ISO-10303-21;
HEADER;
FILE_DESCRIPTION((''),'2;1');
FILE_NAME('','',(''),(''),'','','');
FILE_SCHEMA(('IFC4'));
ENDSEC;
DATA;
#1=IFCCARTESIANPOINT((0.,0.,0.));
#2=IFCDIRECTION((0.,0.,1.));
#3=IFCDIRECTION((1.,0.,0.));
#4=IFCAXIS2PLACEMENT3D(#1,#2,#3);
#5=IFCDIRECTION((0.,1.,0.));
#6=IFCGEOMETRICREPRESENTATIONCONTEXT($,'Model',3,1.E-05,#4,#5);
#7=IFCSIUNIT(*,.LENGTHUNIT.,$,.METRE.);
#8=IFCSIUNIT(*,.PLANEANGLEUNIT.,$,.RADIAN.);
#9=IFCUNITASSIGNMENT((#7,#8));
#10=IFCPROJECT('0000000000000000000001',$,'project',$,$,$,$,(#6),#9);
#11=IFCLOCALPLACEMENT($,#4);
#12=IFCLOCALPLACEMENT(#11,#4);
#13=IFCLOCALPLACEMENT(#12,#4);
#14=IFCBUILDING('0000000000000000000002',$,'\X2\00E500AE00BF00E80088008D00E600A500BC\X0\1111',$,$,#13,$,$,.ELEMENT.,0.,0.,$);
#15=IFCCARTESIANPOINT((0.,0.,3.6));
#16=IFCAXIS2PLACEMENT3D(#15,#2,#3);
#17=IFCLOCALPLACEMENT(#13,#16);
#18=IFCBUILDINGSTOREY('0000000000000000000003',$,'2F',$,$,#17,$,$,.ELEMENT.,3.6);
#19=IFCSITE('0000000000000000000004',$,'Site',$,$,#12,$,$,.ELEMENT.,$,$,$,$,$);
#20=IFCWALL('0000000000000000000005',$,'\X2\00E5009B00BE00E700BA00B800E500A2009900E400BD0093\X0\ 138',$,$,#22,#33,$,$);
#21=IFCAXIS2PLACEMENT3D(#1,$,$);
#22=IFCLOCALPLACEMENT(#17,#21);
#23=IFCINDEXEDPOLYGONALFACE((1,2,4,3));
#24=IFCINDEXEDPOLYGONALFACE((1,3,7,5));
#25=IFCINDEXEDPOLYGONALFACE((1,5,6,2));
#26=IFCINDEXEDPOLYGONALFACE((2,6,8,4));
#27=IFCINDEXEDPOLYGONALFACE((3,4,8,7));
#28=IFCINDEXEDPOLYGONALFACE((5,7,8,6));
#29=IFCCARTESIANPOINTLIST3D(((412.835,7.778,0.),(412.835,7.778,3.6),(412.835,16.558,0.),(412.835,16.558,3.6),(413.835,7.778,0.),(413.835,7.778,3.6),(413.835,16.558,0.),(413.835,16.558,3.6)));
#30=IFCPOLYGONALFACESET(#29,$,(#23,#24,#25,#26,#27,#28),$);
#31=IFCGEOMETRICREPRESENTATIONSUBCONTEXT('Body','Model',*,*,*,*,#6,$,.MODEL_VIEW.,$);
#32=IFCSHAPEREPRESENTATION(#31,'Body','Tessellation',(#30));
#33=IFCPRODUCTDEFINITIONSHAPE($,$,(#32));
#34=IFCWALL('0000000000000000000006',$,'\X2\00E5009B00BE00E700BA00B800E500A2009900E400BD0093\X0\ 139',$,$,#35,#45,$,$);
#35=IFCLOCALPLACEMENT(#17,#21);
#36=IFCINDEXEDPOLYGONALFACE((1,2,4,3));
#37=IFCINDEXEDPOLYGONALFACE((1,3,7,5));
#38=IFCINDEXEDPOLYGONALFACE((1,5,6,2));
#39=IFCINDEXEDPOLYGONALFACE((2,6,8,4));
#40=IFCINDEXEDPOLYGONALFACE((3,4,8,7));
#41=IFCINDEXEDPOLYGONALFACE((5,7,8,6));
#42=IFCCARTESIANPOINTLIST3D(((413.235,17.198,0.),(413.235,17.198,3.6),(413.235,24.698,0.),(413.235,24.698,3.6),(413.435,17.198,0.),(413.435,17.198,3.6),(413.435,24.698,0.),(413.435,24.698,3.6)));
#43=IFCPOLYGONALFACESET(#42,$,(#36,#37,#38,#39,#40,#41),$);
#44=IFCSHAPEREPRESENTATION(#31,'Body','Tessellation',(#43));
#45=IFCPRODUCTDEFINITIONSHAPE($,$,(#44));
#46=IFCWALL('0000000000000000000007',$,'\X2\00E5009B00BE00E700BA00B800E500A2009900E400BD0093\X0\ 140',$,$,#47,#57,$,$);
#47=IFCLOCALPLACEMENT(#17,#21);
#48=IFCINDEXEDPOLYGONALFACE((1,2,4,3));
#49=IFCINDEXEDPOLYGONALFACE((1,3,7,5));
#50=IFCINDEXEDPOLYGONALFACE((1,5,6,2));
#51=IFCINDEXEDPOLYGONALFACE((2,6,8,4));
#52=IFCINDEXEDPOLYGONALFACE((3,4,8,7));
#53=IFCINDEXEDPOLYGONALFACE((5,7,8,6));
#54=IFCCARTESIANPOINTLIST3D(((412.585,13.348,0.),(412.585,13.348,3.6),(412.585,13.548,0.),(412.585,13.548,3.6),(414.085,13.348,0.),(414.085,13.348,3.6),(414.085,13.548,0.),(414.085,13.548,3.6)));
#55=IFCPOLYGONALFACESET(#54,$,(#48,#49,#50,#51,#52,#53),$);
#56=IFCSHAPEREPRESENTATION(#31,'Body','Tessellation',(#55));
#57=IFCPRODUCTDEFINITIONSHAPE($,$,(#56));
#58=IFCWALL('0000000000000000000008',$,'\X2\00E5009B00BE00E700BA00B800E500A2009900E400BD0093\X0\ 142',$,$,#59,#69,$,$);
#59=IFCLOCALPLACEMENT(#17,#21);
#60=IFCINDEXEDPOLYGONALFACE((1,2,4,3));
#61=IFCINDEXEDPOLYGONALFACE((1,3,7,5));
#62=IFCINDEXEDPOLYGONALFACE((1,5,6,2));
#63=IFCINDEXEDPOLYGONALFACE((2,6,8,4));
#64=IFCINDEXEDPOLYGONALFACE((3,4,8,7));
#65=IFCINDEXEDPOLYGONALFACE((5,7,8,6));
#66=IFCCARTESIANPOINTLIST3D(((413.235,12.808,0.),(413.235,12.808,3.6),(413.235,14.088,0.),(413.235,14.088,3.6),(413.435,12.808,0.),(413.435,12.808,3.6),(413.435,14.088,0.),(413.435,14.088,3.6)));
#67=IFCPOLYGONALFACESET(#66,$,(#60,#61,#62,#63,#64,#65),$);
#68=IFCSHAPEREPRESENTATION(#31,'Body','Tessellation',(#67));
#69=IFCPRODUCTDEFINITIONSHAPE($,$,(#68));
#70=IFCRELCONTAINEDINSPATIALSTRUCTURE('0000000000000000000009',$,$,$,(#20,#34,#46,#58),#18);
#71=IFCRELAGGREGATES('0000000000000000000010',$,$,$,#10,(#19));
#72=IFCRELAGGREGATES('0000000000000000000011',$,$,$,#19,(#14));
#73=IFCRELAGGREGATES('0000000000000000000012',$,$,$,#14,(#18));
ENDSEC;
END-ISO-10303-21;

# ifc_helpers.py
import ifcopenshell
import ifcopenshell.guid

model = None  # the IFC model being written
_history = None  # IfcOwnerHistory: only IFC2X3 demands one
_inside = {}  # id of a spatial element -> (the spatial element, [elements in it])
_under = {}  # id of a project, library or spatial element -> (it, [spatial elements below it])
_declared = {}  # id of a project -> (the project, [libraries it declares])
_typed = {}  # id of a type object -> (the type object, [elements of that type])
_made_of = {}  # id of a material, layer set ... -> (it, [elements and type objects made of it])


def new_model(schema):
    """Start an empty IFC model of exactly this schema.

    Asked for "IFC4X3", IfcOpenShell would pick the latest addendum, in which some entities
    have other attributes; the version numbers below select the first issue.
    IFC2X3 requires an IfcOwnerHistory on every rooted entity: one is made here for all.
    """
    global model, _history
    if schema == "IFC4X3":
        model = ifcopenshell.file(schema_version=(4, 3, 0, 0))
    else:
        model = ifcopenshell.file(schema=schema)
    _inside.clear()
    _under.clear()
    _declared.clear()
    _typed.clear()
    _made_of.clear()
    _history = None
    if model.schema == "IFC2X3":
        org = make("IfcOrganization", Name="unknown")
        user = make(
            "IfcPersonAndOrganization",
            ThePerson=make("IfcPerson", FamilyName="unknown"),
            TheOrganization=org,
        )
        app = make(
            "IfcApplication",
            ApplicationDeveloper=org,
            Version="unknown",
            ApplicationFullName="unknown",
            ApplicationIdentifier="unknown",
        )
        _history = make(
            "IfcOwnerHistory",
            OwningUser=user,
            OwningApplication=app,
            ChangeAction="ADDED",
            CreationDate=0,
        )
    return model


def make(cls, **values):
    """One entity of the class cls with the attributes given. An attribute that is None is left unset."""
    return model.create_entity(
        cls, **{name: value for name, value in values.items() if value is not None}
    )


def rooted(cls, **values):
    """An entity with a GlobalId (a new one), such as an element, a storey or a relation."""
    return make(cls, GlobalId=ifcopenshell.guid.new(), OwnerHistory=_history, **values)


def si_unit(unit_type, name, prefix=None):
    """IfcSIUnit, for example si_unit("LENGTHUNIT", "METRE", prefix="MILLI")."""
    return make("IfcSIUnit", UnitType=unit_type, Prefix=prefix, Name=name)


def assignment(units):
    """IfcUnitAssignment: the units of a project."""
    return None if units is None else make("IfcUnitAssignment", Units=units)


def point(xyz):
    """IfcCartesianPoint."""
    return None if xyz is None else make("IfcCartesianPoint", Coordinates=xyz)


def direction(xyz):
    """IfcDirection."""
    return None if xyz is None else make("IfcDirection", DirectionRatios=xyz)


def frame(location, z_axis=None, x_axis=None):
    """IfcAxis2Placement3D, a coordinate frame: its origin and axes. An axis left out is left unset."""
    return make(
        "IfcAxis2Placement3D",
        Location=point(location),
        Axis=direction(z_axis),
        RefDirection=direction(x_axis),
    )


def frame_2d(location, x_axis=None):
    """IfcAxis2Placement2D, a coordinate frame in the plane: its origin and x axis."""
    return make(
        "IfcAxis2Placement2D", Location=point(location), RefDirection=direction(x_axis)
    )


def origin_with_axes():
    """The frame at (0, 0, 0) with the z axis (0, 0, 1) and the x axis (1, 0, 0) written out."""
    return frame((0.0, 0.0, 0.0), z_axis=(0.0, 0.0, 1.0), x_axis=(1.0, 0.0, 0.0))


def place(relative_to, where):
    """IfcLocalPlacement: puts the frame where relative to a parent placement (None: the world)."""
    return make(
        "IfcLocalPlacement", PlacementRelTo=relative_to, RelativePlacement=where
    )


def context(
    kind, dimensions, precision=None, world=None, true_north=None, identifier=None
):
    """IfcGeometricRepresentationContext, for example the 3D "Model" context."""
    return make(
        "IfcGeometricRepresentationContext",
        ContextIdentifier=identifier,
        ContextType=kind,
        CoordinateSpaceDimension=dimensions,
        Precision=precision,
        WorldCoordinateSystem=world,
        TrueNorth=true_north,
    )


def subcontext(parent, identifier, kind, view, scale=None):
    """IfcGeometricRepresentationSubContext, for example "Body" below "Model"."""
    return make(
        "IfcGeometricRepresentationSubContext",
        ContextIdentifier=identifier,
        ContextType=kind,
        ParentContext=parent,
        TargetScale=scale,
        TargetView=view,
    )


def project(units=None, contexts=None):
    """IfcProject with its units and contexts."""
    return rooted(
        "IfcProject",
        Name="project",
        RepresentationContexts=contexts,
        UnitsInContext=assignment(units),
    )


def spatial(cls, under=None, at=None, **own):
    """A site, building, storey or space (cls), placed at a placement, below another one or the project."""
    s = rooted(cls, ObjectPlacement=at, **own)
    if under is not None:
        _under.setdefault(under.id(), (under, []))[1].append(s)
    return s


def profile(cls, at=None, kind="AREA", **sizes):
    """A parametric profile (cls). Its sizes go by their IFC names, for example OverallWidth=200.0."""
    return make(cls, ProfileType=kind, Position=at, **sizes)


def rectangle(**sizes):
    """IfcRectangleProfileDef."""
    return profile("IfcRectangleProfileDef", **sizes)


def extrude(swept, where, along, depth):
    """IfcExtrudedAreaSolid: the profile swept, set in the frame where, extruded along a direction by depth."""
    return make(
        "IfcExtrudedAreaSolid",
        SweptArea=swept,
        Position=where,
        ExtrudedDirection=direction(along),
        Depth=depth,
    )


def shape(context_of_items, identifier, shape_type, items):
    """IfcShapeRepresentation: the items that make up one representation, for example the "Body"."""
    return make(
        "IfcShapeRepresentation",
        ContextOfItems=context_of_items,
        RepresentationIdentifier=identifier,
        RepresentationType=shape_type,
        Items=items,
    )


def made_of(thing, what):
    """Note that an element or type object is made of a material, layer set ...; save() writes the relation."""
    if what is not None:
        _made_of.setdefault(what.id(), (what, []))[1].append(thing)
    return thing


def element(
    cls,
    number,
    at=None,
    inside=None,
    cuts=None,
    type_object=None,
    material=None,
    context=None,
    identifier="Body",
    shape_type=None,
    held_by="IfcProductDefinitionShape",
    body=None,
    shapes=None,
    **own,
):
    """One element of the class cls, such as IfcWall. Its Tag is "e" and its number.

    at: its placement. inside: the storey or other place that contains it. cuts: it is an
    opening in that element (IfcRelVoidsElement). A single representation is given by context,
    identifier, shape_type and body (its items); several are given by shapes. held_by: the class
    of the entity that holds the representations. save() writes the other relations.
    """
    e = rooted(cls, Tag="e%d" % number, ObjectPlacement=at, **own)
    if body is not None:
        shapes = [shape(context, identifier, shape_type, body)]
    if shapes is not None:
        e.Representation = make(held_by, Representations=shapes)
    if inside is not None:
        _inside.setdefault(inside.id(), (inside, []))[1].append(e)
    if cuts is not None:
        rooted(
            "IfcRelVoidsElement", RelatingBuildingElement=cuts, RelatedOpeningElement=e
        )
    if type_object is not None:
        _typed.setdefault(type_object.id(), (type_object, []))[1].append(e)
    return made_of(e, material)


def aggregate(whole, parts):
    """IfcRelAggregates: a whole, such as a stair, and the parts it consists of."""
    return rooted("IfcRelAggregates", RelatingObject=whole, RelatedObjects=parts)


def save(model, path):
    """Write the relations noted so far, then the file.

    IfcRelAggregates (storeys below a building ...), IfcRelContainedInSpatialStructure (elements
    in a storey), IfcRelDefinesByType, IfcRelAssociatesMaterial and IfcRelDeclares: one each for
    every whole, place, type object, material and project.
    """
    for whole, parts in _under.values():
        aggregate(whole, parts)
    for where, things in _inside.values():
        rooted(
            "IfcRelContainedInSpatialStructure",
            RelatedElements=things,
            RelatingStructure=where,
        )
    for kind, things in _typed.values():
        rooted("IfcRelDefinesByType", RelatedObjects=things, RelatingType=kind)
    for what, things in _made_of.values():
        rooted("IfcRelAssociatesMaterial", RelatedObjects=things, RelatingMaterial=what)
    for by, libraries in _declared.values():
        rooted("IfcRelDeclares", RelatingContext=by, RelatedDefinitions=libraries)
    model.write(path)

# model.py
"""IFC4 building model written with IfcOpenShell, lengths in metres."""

from ifc_helpers import new_model, si_unit, direction, frame, frame_2d, origin_with_axes, place, context, subcontext, project, spatial, rectangle, extrude, element, save


model = new_model("IFC4")

# Units and contexts
model_context = context("Model", 3, precision=1e-05, world=origin_with_axes(), true_north=direction((0.0, 1.0, 0.0)))
body_context = subcontext(model_context, "Body", "Model", "MODEL_VIEW")
ifc_project = project(units=[si_unit("LENGTHUNIT", "METRE"), si_unit("PLANEANGLEUNIT", "RADIAN")], contexts=[model_context])

# Site, building, storey
placement = place(None, origin_with_axes())
site_placement = place(placement, origin_with_axes())
site = spatial("IfcSite", under=ifc_project, at=site_placement, Name="Site", CompositionType="ELEMENT")
building_placement = place(site_placement, origin_with_axes())
building = spatial("IfcBuilding", under=site, at=building_placement, Name="å®¿è\u0088\u008dæ¥¼1111", CompositionType="ELEMENT", ElevationOfRefHeight=0.0, ElevationOfTerrain=0.0)
storey_placement = place(building_placement, frame((0.0, 0.0, 3.6), z_axis=(0.0, 0.0, 1.0), x_axis=(1.0, 0.0, 0.0)))
storey = spatial("IfcBuildingStorey", under=building, at=storey_placement, Name="2F", CompositionType="ELEMENT", Elevation=3.6)

# Walls
wall_1_placement = place(storey_placement, frame((413.335, 12.168, 0.0), z_axis=(0.0, 0.0, 1.0), x_axis=(1.0, 0.0, 0.0)))
element("IfcWall", 1, at=wall_1_placement, inside=storey, Name="å\u009b¾çº¸å¢\u0099ä½\u0093 138", context=body_context, shape_type="SweptSolid", body=[
    extrude(rectangle(XDim=1.0, YDim=8.78, at=frame_2d((0.0, 0.0), x_axis=(1.0, 0.0, 0.0))), frame((0.0, 0.0, 0.0), z_axis=(0.0, 0.0, 1.0)), (0.0, 0.0, 1.0), 3.6),
])
wall_2_placement = place(storey_placement, frame((413.335, 20.948, 0.0), z_axis=(0.0, 0.0, 1.0), x_axis=(0.0, -1.0, 0.0)))
element("IfcWall", 2, at=wall_2_placement, inside=storey, Name="å\u009b¾çº¸å¢\u0099ä½\u0093 139", context=body_context, shape_type="SweptSolid", body=[
    extrude(rectangle(XDim=7.5, YDim=0.2, at=frame_2d((0.0, 0.0), x_axis=(1.0, 0.0, 0.0))), frame((0.0, 0.0, 0.0), z_axis=(0.0, 0.0, 1.0)), (0.0, 0.0, 1.0), 3.6),
])
wall_3_placement = place(storey_placement, frame((413.335, 13.448, 0.0), z_axis=(0.0, 0.0, 1.0), x_axis=(1.0, 0.0, 0.0)))
element("IfcWall", 3, at=wall_3_placement, inside=storey, Name="å\u009b¾çº¸å¢\u0099ä½\u0093 140", context=body_context, shape_type="SweptSolid", body=[
    extrude(rectangle(XDim=1.5, YDim=0.2, at=frame_2d((0.0, 0.0), x_axis=(1.0, 0.0, 0.0))), frame((0.0, 0.0, 0.0), z_axis=(0.0, 0.0, 1.0)), (0.0, 0.0, 1.0), 3.6),
])
wall_4_placement = place(storey_placement, frame((413.335, 13.448, 0.0), z_axis=(0.0, 0.0, 1.0), x_axis=(0.0, -1.0, 0.0)))
element("IfcWall", 4, at=wall_4_placement, inside=storey, Name="å\u009b¾çº¸å¢\u0099ä½\u0093 142", context=body_context, shape_type="SweptSolid", body=[
    extrude(rectangle(XDim=1.28, YDim=0.2, at=frame_2d((0.0, 0.0), x_axis=(1.0, 0.0, 0.0))), frame((0.0, 0.0, 0.0), z_axis=(0.0, 0.0, 1.0)), (0.0, 0.0, 1.0), 3.6),
])

save(model, "model.ifc")
